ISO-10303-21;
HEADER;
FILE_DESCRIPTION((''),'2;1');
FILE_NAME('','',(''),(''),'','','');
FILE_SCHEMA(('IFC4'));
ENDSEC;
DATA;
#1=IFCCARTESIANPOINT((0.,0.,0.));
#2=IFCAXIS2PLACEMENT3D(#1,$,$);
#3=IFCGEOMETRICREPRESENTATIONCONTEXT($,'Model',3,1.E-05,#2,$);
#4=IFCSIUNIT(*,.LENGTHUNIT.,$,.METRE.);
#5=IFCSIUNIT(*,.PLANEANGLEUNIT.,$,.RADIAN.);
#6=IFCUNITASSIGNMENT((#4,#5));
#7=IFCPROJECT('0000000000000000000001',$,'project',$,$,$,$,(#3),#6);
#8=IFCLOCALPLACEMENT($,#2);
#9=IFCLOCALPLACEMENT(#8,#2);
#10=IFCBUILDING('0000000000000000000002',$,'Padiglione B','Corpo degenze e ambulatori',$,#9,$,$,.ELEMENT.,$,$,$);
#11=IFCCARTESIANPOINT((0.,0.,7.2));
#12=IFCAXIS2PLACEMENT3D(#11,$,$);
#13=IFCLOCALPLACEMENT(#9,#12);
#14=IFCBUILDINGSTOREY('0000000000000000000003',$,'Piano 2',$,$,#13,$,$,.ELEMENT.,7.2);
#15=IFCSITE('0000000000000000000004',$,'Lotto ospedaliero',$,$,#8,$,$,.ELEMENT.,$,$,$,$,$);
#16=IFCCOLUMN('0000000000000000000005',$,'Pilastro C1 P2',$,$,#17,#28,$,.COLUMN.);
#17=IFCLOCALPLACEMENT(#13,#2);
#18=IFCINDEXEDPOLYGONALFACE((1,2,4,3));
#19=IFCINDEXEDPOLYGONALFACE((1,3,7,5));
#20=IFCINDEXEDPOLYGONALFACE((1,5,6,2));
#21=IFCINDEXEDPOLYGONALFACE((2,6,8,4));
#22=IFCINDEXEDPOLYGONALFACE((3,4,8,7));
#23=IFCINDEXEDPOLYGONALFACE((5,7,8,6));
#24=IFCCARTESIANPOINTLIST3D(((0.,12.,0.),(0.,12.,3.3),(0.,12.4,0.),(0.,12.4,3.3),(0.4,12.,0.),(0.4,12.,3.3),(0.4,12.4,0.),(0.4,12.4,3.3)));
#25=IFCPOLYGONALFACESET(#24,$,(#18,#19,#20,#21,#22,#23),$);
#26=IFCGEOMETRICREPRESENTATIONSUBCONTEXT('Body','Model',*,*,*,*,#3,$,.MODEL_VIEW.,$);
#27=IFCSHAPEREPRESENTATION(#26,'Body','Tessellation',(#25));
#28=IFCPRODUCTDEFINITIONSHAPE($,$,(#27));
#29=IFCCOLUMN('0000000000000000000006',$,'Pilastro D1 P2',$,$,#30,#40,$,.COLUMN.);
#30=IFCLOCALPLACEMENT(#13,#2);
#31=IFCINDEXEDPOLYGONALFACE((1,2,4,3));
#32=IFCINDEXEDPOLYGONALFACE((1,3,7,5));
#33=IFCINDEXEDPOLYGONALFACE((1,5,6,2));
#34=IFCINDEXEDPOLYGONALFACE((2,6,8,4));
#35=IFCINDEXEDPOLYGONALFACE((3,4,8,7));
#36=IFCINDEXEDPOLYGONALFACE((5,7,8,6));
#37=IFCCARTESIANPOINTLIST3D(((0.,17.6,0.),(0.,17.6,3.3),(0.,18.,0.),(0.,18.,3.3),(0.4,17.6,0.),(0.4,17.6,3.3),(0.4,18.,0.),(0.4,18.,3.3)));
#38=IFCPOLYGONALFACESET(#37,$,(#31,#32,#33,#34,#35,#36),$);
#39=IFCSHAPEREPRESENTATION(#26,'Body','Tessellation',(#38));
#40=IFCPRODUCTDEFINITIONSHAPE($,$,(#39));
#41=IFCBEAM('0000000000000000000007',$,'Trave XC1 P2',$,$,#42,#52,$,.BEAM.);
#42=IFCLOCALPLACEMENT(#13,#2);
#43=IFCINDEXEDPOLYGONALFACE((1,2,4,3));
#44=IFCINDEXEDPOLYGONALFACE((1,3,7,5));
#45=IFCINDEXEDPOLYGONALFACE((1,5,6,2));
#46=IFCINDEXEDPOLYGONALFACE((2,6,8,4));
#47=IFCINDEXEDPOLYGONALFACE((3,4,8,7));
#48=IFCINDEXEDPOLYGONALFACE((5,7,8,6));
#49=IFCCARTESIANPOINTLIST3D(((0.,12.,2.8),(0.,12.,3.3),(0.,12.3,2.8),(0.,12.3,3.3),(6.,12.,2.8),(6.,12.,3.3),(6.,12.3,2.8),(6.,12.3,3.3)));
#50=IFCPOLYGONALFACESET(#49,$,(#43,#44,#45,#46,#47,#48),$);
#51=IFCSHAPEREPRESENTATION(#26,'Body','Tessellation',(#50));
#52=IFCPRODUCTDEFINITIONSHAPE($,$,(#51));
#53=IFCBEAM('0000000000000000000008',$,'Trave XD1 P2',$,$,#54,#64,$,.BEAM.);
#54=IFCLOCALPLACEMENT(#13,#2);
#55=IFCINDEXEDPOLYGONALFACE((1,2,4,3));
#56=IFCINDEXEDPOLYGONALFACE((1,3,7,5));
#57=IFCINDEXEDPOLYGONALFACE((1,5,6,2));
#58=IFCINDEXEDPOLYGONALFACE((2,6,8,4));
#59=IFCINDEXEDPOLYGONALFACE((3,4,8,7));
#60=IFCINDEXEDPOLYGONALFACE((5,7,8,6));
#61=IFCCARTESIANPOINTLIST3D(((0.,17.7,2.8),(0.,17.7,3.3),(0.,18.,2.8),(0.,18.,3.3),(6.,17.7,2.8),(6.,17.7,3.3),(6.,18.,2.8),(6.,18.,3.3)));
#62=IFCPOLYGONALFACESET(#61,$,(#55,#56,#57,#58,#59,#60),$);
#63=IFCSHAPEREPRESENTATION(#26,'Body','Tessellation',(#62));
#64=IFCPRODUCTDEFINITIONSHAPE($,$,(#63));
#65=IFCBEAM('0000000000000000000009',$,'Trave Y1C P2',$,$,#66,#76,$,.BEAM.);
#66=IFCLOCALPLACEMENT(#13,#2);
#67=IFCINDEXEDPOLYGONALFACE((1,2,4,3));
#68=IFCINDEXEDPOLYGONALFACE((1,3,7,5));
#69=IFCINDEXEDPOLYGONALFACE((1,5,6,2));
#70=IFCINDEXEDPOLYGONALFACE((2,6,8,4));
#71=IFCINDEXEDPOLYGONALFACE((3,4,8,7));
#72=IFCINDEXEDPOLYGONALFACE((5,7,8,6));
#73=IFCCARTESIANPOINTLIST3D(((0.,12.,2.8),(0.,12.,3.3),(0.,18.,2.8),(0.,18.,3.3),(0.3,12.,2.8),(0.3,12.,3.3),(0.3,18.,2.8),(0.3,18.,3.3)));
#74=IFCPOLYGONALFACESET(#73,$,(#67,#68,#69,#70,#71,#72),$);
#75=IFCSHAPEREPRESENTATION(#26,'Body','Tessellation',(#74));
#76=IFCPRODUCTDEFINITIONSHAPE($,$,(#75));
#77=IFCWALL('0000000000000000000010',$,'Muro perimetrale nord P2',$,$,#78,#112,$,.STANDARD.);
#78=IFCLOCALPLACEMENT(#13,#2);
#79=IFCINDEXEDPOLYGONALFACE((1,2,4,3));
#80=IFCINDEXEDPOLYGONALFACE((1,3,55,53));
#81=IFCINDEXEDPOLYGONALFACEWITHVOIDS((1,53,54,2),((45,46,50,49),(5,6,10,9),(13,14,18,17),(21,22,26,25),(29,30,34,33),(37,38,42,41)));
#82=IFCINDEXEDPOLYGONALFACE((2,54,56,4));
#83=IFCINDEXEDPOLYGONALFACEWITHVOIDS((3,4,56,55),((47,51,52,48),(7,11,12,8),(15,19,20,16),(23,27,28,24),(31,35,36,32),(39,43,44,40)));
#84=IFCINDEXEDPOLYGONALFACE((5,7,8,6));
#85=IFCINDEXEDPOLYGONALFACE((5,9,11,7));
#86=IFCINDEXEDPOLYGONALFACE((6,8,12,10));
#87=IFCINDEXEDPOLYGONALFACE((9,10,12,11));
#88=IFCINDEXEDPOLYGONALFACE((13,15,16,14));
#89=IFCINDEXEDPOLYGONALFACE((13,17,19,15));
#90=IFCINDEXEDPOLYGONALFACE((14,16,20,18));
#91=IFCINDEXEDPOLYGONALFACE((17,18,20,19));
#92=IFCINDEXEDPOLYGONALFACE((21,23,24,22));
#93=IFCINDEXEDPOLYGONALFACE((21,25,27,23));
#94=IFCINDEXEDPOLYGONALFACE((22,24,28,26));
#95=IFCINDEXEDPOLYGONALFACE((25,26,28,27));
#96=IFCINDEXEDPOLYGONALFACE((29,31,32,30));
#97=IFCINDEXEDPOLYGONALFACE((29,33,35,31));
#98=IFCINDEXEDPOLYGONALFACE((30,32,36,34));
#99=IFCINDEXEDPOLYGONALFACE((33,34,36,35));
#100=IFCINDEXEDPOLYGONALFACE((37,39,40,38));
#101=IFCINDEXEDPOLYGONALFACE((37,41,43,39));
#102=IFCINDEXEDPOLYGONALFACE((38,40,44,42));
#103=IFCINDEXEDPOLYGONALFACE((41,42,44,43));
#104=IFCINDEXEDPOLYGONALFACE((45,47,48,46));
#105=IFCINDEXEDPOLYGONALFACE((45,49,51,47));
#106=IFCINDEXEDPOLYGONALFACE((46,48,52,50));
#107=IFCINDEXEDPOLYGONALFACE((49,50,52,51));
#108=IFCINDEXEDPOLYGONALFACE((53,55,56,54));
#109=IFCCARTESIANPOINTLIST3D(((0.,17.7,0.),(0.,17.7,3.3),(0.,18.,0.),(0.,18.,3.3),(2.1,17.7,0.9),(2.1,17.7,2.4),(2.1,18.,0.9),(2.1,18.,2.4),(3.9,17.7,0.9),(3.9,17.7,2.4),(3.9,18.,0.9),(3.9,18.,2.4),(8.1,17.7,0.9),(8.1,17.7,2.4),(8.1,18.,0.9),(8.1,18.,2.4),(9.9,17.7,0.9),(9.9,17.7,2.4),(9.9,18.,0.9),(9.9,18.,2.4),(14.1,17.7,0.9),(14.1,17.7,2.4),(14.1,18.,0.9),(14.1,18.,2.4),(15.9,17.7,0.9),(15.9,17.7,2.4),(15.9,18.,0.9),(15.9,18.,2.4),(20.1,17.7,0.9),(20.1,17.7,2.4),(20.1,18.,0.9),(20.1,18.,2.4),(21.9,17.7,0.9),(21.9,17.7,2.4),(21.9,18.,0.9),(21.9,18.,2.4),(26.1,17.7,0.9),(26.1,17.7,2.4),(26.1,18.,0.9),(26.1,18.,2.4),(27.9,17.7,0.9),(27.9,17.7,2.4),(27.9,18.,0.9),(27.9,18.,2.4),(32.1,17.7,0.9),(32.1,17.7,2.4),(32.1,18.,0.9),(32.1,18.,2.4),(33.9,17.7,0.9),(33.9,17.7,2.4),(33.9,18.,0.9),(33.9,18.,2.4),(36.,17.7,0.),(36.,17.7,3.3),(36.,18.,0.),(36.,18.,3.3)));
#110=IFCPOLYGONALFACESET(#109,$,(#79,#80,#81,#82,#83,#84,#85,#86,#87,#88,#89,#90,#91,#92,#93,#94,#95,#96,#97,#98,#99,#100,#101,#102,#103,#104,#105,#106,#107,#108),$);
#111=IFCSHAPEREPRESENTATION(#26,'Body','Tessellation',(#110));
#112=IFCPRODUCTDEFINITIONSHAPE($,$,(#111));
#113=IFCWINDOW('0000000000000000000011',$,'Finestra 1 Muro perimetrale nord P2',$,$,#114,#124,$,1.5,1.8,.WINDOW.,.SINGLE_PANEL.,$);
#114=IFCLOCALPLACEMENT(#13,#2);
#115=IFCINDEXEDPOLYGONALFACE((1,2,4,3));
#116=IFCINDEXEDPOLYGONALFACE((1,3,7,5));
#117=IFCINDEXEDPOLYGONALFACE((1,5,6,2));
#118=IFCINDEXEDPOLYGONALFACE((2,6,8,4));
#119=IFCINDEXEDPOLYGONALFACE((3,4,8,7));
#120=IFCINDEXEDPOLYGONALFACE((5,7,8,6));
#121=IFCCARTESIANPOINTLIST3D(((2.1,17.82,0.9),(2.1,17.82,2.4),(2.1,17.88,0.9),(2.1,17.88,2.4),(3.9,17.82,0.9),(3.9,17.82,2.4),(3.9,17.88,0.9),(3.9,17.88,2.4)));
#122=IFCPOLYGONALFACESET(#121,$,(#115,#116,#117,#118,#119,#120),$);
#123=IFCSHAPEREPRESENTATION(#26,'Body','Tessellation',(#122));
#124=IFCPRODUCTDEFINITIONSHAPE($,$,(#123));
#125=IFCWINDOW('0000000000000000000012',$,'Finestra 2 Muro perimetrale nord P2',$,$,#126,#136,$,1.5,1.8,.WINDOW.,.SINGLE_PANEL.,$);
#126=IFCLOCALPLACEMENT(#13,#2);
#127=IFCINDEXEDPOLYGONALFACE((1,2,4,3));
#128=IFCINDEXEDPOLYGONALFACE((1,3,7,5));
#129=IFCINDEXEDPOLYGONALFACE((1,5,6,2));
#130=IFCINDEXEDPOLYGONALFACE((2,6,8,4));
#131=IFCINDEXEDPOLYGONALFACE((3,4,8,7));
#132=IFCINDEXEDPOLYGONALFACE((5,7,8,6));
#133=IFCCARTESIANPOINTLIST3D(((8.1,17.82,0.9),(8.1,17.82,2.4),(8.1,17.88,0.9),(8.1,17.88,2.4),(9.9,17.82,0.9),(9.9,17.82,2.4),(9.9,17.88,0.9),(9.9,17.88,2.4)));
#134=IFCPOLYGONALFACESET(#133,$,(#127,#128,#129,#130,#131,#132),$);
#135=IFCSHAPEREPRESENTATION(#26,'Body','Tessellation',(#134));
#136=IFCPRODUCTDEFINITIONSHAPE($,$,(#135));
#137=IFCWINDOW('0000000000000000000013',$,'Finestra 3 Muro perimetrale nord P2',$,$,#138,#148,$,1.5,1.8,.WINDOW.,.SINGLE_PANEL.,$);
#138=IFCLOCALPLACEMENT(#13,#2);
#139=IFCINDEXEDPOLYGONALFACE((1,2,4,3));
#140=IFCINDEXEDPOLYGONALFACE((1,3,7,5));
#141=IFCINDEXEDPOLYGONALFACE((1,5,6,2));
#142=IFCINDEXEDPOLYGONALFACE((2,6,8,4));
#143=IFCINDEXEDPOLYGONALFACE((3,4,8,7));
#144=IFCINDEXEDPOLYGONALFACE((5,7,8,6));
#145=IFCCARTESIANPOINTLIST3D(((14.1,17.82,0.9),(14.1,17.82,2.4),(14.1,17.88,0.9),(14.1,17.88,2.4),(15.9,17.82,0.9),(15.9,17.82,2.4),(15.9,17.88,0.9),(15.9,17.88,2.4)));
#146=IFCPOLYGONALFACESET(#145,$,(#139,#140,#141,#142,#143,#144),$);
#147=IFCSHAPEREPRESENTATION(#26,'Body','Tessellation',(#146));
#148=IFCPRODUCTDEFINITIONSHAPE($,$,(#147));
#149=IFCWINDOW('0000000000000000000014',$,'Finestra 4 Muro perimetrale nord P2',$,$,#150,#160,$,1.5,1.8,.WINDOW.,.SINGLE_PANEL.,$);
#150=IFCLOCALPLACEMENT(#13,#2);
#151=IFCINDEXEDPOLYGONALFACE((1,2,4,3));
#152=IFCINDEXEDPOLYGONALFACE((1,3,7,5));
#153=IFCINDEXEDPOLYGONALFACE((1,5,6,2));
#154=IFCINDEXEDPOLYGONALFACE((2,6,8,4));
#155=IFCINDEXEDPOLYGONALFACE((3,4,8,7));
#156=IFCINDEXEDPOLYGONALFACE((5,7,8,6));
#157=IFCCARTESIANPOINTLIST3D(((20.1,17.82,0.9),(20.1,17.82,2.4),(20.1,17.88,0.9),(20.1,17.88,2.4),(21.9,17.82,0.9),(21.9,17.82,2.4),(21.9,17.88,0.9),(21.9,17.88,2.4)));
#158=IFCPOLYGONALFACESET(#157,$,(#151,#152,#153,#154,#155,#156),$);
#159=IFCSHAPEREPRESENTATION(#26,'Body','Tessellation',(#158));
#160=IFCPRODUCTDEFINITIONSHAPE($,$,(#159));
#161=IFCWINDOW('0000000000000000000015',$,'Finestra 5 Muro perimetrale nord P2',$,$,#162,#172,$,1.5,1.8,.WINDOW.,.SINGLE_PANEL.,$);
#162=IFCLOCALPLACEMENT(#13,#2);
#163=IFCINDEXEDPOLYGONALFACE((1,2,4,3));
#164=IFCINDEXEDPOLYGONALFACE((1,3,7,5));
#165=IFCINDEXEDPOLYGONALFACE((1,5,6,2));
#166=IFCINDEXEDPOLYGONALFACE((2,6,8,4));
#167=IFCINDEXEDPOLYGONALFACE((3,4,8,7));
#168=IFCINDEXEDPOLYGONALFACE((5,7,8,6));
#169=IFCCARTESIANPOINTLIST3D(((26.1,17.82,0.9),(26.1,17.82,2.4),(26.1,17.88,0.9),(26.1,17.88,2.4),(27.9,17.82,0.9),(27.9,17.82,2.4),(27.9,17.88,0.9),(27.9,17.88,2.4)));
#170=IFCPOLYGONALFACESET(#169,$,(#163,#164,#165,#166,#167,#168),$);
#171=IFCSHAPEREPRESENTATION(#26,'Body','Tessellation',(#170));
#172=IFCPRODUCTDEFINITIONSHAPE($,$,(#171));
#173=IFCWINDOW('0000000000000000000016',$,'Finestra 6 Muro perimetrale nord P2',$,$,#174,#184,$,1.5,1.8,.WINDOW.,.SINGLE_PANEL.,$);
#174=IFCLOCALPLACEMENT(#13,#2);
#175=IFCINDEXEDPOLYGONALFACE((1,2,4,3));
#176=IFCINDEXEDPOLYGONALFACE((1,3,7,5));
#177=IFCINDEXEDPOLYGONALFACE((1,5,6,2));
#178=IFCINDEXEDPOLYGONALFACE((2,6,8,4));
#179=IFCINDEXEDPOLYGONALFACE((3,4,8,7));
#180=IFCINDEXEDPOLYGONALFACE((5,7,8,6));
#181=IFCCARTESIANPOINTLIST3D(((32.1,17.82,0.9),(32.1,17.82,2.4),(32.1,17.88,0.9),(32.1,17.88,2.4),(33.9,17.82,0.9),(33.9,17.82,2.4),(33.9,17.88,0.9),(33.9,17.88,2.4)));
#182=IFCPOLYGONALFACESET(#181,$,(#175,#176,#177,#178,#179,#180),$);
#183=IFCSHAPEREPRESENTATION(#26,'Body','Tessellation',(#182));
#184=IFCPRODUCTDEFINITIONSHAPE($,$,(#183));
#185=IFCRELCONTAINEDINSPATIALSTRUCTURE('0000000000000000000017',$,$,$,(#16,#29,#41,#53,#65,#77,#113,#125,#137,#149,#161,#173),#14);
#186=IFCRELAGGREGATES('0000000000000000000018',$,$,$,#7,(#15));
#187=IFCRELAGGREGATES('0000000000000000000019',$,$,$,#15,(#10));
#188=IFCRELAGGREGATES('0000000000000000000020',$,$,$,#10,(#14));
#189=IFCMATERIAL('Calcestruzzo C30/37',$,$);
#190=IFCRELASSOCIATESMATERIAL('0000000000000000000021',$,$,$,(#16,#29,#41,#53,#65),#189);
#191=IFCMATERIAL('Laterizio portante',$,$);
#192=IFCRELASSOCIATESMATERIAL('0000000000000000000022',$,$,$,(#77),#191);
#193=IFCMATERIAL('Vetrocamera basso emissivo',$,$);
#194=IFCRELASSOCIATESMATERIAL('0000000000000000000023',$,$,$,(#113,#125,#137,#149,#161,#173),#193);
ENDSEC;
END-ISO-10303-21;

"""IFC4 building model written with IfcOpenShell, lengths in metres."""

from ifc_helpers import new_model, si_unit, frame, frame_2d, origin, place, context, subcontext, project, spatial, rectangle, extrude, material, element, fill, save


model = new_model("IFC4")

# Units and contexts
model_context = context("Model", 3, precision=1e-05, world=origin())
body_context = subcontext(model_context, "Body", "Model", "MODEL_VIEW")
ifc_project = project(units=[si_unit("LENGTHUNIT", "METRE"), si_unit("PLANEANGLEUNIT", "RADIAN")], contexts=[model_context])

# Site, building, storey
site_placement = place(None, origin())
site = spatial("IfcSite", under=ifc_project, at=site_placement, Name="Lotto ospedaliero", CompositionType="ELEMENT")
building_placement = place(site_placement, origin())
building = spatial("IfcBuilding", under=site, at=building_placement, Name="Padiglione B", Description="Corpo degenze e ambulatori", CompositionType="ELEMENT")
storey_placement = place(building_placement, frame((0.0, 0.0, 7.2)))
storey = spatial("IfcBuildingStorey", under=building, at=storey_placement, Name="Piano 2", CompositionType="ELEMENT", Elevation=7.2)

# Columns
ifc_material_1 = material(Name="Calcestruzzo C30/37")
for number, where, name in (
    (1, (0.0, 12.0, 0.0), "Pilastro C1 P2"),
    (2, (0.0, 17.6, 0.0), "Pilastro D1 P2"),
):
    element("IfcColumn", number, at=place(storey_placement, frame(where)), inside=storey, material=ifc_material_1, Name=name, PredefinedType="COLUMN", context=body_context, shape_type="SweptSolid", body=[
        extrude(rectangle(XDim=0.4, YDim=0.4, at=frame_2d((0.2, 0.2))), origin(), (0.0, 0.0, 1.0), 3.3),
    ])

# Beams
for number, where, name in (
    (3, (0.0, 12.0, 2.8), "Trave XC1 P2"),
    (4, (0.0, 17.7, 2.8), "Trave XD1 P2"),
):
    element("IfcBeam", number, at=place(storey_placement, frame(where)), inside=storey, material=ifc_material_1, Name=name, PredefinedType="BEAM", context=body_context, shape_type="SweptSolid", body=[
        extrude(rectangle(XDim=6.0, YDim=0.3, at=frame_2d((3.0, 0.15))), origin(), (0.0, 0.0, 1.0), 0.5),
    ])
beam_placement = place(storey_placement, frame((0.0, 12.0, 2.8)))
element("IfcBeam", 5, at=beam_placement, inside=storey, material=ifc_material_1, Name="Trave Y1C P2", PredefinedType="BEAM", context=body_context, shape_type="SweptSolid", body=[
    extrude(rectangle(XDim=0.3, YDim=6.0, at=frame_2d((0.15, 3.0))), origin(), (0.0, 0.0, 1.0), 0.5),
])

# Wall, openings, windows
ifc_material_2 = material(Name="Laterizio portante")
wall_placement = place(storey_placement, frame((0.0, 17.7, 0.0)))
wall = element("IfcWall", 6, at=wall_placement, inside=storey, material=ifc_material_2, Name="Muro perimetrale nord P2", PredefinedType="STANDARD", context=body_context, shape_type="SweptSolid", body=[
    extrude(rectangle(XDim=36.0, YDim=0.3, at=frame_2d((18.0, 0.15))), origin(), (0.0, 0.0, 1.0), 3.3),
])
opening_1_placement = place(wall_placement, frame((2.1, -0.1, 0.9)))
opening_1 = element("IfcOpeningElement", 7, at=opening_1_placement, cuts=wall, PredefinedType="OPENING", context=body_context, shape_type="SweptSolid", body=[
    extrude(rectangle(XDim=1.8, YDim=0.5, at=frame_2d((0.9, 0.25))), origin(), (0.0, 0.0, 1.0), 1.5),
])
opening_2_placement = place(wall_placement, frame((8.1, -0.1, 0.9)))
opening_2 = element("IfcOpeningElement", 8, at=opening_2_placement, cuts=wall, PredefinedType="OPENING", context=body_context, shape_type="SweptSolid", body=[
    extrude(rectangle(XDim=1.8, YDim=0.5, at=frame_2d((0.9, 0.25))), origin(), (0.0, 0.0, 1.0), 1.5),
])
opening_3_placement = place(wall_placement, frame((14.1, -0.1, 0.9)))
opening_3 = element("IfcOpeningElement", 9, at=opening_3_placement, cuts=wall, PredefinedType="OPENING", context=body_context, shape_type="SweptSolid", body=[
    extrude(rectangle(XDim=1.8, YDim=0.5, at=frame_2d((0.9, 0.25))), origin(), (0.0, 0.0, 1.0), 1.5),
])
opening_4_placement = place(wall_placement, frame((20.1, -0.1, 0.9)))
opening_4 = element("IfcOpeningElement", 10, at=opening_4_placement, cuts=wall, PredefinedType="OPENING", context=body_context, shape_type="SweptSolid", body=[
    extrude(rectangle(XDim=1.8, YDim=0.5, at=frame_2d((0.9, 0.25))), origin(), (0.0, 0.0, 1.0), 1.5),
])
opening_5_placement = place(wall_placement, frame((26.1, -0.1, 0.9)))
opening_5 = element("IfcOpeningElement", 11, at=opening_5_placement, cuts=wall, PredefinedType="OPENING", context=body_context, shape_type="SweptSolid", body=[
    extrude(rectangle(XDim=1.8, YDim=0.5, at=frame_2d((0.9, 0.25))), origin(), (0.0, 0.0, 1.0), 1.5),
])
opening_6_placement = place(wall_placement, frame((32.1, -0.1, 0.9)))
opening_6 = element("IfcOpeningElement", 12, at=opening_6_placement, cuts=wall, PredefinedType="OPENING", context=body_context, shape_type="SweptSolid", body=[
    extrude(rectangle(XDim=1.8, YDim=0.5, at=frame_2d((0.9, 0.25))), origin(), (0.0, 0.0, 1.0), 1.5),
])
ifc_material_3 = material(Name="Vetrocamera basso emissivo")
window_1_placement = place(wall_placement, frame((2.1, 0.12, 0.9)))
window_1 = element("IfcWindow", 13, at=window_1_placement, inside=storey, material=ifc_material_3, Name="Finestra 1 Muro perimetrale nord P2", OverallHeight=1.5, OverallWidth=1.8, PartitioningType="SINGLE_PANEL", PredefinedType="WINDOW", context=body_context, shape_type="SweptSolid", body=[
    extrude(rectangle(XDim=1.8, YDim=0.06, at=frame_2d((0.9, 0.03))), origin(), (0.0, 0.0, 1.0), 1.5),
])
fill(opening_1, window_1)
window_2_placement = place(wall_placement, frame((8.1, 0.12, 0.9)))
window_2 = element("IfcWindow", 14, at=window_2_placement, inside=storey, material=ifc_material_3, Name="Finestra 2 Muro perimetrale nord P2", OverallHeight=1.5, OverallWidth=1.8, PartitioningType="SINGLE_PANEL", PredefinedType="WINDOW", context=body_context, shape_type="SweptSolid", body=[
    extrude(rectangle(XDim=1.8, YDim=0.06, at=frame_2d((0.9, 0.03))), origin(), (0.0, 0.0, 1.0), 1.5),
])
fill(opening_2, window_2)
window_3_placement = place(wall_placement, frame((14.1, 0.12, 0.9)))
window_3 = element("IfcWindow", 15, at=window_3_placement, inside=storey, material=ifc_material_3, Name="Finestra 3 Muro perimetrale nord P2", OverallHeight=1.5, OverallWidth=1.8, PartitioningType="SINGLE_PANEL", PredefinedType="WINDOW", context=body_context, shape_type="SweptSolid", body=[
    extrude(rectangle(XDim=1.8, YDim=0.06, at=frame_2d((0.9, 0.03))), origin(), (0.0, 0.0, 1.0), 1.5),
])
fill(opening_3, window_3)
window_4_placement = place(wall_placement, frame((20.1, 0.12, 0.9)))
window_4 = element("IfcWindow", 16, at=window_4_placement, inside=storey, material=ifc_material_3, Name="Finestra 4 Muro perimetrale nord P2", OverallHeight=1.5, OverallWidth=1.8, PartitioningType="SINGLE_PANEL", PredefinedType="WINDOW", context=body_context, shape_type="SweptSolid", body=[
    extrude(rectangle(XDim=1.8, YDim=0.06, at=frame_2d((0.9, 0.03))), origin(), (0.0, 0.0, 1.0), 1.5),
])
fill(opening_4, window_4)
window_5_placement = place(wall_placement, frame((26.1, 0.12, 0.9)))
window_5 = element("IfcWindow", 17, at=window_5_placement, inside=storey, material=ifc_material_3, Name="Finestra 5 Muro perimetrale nord P2", OverallHeight=1.5, OverallWidth=1.8, PartitioningType="SINGLE_PANEL", PredefinedType="WINDOW", context=body_context, shape_type="SweptSolid", body=[
    extrude(rectangle(XDim=1.8, YDim=0.06, at=frame_2d((0.9, 0.03))), origin(), (0.0, 0.0, 1.0), 1.5),
])
fill(opening_5, window_5)
window_6_placement = place(wall_placement, frame((32.1, 0.12, 0.9)))
window_6 = element("IfcWindow", 18, at=window_6_placement, inside=storey, material=ifc_material_3, Name="Finestra 6 Muro perimetrale nord P2", OverallHeight=1.5, OverallWidth=1.8, PartitioningType="SINGLE_PANEL", PredefinedType="WINDOW", context=body_context, shape_type="SweptSolid", body=[
    extrude(rectangle(XDim=1.8, YDim=0.06, at=frame_2d((0.9, 0.03))), origin(), (0.0, 0.0, 1.0), 1.5),
])
fill(opening_6, window_6)

save(model, "model.ifc")
